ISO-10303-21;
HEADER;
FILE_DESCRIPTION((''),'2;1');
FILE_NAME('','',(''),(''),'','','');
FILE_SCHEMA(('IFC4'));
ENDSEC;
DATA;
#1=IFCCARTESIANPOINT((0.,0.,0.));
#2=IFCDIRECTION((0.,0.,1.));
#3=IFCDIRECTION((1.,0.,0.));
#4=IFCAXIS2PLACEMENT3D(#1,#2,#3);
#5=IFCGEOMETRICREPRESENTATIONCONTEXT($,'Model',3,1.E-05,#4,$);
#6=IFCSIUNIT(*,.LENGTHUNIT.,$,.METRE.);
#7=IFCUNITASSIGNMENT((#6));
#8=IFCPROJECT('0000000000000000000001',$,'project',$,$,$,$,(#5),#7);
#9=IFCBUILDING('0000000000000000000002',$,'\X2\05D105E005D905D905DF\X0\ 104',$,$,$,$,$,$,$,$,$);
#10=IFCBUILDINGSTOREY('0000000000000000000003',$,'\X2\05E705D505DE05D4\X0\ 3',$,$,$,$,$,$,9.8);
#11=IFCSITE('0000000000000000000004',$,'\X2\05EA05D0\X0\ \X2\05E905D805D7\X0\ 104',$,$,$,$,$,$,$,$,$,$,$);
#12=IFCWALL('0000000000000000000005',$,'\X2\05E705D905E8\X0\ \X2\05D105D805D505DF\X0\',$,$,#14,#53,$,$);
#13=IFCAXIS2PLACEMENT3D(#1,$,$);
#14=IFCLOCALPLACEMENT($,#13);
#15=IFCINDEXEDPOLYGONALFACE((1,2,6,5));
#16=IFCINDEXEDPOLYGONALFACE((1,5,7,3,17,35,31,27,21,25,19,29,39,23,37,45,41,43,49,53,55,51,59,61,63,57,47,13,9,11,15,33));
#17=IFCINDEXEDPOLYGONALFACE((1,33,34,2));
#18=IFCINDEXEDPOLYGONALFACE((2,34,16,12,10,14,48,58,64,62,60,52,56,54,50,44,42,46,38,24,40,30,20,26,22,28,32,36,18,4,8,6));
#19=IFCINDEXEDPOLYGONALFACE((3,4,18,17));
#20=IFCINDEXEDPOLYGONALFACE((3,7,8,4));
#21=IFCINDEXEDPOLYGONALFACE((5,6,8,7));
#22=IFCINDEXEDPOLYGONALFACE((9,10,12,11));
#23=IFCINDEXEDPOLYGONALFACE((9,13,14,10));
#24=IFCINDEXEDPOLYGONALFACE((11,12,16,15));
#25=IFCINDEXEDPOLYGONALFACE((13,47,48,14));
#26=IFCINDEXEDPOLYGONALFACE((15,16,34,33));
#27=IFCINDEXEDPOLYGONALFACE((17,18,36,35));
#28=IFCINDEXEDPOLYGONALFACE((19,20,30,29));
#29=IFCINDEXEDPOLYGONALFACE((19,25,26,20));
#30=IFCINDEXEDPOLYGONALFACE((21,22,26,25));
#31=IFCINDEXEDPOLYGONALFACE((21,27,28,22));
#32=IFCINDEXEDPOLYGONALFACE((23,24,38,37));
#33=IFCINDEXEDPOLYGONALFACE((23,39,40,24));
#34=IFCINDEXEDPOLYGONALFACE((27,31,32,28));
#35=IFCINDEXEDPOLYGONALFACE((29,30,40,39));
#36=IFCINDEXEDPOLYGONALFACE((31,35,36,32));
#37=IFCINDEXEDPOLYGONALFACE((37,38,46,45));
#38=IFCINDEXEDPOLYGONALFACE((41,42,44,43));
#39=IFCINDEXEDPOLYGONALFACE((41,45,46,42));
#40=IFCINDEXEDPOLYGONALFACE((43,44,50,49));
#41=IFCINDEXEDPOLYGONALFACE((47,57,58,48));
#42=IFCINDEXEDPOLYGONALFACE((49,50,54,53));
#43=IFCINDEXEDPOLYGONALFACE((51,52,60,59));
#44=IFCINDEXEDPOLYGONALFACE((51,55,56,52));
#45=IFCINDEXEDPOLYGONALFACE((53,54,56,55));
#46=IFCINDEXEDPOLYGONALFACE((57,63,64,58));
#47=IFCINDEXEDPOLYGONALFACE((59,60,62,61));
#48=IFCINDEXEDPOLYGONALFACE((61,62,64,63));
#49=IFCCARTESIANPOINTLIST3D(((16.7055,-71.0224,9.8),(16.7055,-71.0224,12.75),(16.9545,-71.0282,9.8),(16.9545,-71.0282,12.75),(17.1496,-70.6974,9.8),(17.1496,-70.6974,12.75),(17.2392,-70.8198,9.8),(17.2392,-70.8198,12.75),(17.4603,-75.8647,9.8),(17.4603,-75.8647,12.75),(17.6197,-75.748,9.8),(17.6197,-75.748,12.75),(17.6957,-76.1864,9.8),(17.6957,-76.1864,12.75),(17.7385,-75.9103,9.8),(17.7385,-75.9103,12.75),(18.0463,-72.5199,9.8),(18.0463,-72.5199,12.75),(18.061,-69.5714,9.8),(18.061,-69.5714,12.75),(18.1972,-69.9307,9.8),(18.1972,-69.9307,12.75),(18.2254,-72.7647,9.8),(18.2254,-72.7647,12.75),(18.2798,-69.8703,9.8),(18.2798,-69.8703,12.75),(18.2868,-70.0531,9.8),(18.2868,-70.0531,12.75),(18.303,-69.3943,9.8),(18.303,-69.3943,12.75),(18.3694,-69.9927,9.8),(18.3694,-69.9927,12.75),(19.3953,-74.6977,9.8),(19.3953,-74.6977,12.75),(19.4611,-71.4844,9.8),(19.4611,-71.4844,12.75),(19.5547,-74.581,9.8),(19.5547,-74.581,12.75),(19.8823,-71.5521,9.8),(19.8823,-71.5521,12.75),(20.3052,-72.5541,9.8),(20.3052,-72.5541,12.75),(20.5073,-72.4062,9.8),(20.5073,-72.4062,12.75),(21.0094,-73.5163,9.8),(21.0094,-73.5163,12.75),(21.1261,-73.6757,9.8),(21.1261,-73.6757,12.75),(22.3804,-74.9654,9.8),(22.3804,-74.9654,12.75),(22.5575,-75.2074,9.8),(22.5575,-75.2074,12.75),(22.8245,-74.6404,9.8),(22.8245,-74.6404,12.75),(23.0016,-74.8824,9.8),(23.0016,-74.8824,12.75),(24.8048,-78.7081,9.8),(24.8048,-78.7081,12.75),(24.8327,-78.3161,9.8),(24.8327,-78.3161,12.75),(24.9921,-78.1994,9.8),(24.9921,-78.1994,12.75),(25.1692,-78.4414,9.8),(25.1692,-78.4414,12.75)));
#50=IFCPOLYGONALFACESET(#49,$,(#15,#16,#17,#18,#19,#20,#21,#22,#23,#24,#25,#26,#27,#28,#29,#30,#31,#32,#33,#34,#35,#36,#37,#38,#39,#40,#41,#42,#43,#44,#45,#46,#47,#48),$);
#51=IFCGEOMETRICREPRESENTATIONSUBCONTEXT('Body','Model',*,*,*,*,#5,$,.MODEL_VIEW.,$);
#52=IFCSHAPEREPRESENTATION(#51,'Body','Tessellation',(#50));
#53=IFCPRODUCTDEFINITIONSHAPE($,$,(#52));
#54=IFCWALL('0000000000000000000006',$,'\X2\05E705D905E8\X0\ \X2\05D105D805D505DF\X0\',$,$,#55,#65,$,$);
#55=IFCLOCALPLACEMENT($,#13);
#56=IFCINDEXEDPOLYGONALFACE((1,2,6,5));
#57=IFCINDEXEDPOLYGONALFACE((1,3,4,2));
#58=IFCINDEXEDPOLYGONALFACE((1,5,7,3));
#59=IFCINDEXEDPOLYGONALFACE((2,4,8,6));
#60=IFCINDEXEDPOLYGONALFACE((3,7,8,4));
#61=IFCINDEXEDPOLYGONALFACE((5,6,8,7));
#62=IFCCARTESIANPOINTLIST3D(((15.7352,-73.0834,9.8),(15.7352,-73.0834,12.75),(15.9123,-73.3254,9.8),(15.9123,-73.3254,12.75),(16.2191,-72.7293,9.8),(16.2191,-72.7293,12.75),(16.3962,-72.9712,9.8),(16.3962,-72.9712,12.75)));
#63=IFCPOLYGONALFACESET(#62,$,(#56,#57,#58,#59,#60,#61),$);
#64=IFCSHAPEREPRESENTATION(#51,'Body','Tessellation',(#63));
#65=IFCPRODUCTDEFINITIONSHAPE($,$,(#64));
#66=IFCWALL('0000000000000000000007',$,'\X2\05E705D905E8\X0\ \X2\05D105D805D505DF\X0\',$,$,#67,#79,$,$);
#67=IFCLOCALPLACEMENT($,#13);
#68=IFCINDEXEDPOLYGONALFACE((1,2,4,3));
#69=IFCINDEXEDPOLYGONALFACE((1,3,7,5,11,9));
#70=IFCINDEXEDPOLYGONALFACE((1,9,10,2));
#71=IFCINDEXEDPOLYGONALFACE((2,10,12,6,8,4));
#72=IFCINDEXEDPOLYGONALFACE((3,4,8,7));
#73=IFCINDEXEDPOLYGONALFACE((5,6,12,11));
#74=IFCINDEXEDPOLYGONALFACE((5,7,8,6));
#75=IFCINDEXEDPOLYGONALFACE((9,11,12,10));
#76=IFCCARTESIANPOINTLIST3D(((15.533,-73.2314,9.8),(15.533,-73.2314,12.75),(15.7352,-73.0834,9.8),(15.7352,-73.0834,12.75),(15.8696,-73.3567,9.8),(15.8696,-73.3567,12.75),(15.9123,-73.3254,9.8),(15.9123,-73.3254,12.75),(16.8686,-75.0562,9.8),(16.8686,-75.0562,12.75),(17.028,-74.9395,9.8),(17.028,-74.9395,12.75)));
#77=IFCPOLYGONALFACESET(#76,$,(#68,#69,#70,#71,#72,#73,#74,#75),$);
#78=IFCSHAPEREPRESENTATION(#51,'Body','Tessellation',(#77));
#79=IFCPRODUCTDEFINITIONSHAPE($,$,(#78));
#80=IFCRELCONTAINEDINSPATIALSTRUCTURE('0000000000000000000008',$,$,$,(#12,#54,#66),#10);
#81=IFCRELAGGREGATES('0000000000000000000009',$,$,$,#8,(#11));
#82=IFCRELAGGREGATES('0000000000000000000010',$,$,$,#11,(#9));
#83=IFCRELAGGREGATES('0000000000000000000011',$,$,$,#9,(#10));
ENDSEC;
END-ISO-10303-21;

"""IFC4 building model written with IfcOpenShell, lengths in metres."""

from ifc_helpers import new_model, si_unit, frame, origin_with_axes, context, subcontext, project, spatial, polyline, outline, extrude, element, save


model = new_model("IFC4")

# Units and contexts
model_context = context("Model", 3, precision=1e-05, world=origin_with_axes())
body_context = subcontext(model_context, "Body", "Model", "MODEL_VIEW")
ifc_project = project(units=[si_unit("LENGTHUNIT", "METRE")], contexts=[model_context])

# Site, building, storey
site = spatial("IfcSite", under=ifc_project, Name="תא שטח 104")
building = spatial("IfcBuilding", under=site, Name="בניין 104")
storey = spatial("IfcBuildingStorey", under=building, Name="קומה 3", Elevation=9.8)

# Walls
element("IfcWall", 1, inside=storey, Name="קיר בטון", context=body_context, shape_type="SweptSolid", body=[
    extrude(outline(polyline([(18.2868, -70.0531), (18.3694, -69.9927), (19.4611, -71.4844), (18.0463, -72.5199), (16.9545, -71.0282), (17.2392, -70.8198), (17.1496, -70.6974), (16.7055, -71.0224), (19.3953, -74.6977), (17.7385, -75.9103), (17.6197, -75.748), (17.4603, -75.8647), (17.6957, -76.1864), (21.1261, -73.6757), (24.8048, -78.7081), (25.1692, -78.4414), (24.9921, -78.1994), (24.8327, -78.3161), (22.5575, -75.2074), (23.0016, -74.8824), (22.8245, -74.6404), (22.3804, -74.9654), (20.5073, -72.4062), (20.3052, -72.5541), (21.0094, -73.5163), (19.5547, -74.581), (18.2254, -72.7647), (19.8823, -71.5521), (18.303, -69.3943), (18.061, -69.5714), (18.2798, -69.8703), (18.1972, -69.9307), (18.2868, -70.0531)])), frame((0.0, 0.0, 9.8)), (0.0, 0.0, 1.0), 2.95),
])
element("IfcWall", 2, inside=storey, Name="קיר בטון", context=body_context, shape_type="SweptSolid", body=[
    extrude(outline(polyline([(15.9123, -73.3254), (16.3962, -72.9712), (16.2191, -72.7293), (15.7352, -73.0834), (15.9123, -73.3254)])), frame((0.0, 0.0, 9.8)), (0.0, 0.0, 1.0), 2.95),
])
element("IfcWall", 3, inside=storey, Name="קיר בטון", context=body_context, shape_type="SweptSolid", body=[
    extrude(outline(polyline([(15.533, -73.2314), (16.8686, -75.0562), (17.028, -74.9395), (15.8696, -73.3567), (15.9123, -73.3254), (15.7352, -73.0834), (15.533, -73.2314)])), frame((0.0, 0.0, 9.8)), (0.0, 0.0, 1.0), 2.95),
])

save(model, "model.ifc")
